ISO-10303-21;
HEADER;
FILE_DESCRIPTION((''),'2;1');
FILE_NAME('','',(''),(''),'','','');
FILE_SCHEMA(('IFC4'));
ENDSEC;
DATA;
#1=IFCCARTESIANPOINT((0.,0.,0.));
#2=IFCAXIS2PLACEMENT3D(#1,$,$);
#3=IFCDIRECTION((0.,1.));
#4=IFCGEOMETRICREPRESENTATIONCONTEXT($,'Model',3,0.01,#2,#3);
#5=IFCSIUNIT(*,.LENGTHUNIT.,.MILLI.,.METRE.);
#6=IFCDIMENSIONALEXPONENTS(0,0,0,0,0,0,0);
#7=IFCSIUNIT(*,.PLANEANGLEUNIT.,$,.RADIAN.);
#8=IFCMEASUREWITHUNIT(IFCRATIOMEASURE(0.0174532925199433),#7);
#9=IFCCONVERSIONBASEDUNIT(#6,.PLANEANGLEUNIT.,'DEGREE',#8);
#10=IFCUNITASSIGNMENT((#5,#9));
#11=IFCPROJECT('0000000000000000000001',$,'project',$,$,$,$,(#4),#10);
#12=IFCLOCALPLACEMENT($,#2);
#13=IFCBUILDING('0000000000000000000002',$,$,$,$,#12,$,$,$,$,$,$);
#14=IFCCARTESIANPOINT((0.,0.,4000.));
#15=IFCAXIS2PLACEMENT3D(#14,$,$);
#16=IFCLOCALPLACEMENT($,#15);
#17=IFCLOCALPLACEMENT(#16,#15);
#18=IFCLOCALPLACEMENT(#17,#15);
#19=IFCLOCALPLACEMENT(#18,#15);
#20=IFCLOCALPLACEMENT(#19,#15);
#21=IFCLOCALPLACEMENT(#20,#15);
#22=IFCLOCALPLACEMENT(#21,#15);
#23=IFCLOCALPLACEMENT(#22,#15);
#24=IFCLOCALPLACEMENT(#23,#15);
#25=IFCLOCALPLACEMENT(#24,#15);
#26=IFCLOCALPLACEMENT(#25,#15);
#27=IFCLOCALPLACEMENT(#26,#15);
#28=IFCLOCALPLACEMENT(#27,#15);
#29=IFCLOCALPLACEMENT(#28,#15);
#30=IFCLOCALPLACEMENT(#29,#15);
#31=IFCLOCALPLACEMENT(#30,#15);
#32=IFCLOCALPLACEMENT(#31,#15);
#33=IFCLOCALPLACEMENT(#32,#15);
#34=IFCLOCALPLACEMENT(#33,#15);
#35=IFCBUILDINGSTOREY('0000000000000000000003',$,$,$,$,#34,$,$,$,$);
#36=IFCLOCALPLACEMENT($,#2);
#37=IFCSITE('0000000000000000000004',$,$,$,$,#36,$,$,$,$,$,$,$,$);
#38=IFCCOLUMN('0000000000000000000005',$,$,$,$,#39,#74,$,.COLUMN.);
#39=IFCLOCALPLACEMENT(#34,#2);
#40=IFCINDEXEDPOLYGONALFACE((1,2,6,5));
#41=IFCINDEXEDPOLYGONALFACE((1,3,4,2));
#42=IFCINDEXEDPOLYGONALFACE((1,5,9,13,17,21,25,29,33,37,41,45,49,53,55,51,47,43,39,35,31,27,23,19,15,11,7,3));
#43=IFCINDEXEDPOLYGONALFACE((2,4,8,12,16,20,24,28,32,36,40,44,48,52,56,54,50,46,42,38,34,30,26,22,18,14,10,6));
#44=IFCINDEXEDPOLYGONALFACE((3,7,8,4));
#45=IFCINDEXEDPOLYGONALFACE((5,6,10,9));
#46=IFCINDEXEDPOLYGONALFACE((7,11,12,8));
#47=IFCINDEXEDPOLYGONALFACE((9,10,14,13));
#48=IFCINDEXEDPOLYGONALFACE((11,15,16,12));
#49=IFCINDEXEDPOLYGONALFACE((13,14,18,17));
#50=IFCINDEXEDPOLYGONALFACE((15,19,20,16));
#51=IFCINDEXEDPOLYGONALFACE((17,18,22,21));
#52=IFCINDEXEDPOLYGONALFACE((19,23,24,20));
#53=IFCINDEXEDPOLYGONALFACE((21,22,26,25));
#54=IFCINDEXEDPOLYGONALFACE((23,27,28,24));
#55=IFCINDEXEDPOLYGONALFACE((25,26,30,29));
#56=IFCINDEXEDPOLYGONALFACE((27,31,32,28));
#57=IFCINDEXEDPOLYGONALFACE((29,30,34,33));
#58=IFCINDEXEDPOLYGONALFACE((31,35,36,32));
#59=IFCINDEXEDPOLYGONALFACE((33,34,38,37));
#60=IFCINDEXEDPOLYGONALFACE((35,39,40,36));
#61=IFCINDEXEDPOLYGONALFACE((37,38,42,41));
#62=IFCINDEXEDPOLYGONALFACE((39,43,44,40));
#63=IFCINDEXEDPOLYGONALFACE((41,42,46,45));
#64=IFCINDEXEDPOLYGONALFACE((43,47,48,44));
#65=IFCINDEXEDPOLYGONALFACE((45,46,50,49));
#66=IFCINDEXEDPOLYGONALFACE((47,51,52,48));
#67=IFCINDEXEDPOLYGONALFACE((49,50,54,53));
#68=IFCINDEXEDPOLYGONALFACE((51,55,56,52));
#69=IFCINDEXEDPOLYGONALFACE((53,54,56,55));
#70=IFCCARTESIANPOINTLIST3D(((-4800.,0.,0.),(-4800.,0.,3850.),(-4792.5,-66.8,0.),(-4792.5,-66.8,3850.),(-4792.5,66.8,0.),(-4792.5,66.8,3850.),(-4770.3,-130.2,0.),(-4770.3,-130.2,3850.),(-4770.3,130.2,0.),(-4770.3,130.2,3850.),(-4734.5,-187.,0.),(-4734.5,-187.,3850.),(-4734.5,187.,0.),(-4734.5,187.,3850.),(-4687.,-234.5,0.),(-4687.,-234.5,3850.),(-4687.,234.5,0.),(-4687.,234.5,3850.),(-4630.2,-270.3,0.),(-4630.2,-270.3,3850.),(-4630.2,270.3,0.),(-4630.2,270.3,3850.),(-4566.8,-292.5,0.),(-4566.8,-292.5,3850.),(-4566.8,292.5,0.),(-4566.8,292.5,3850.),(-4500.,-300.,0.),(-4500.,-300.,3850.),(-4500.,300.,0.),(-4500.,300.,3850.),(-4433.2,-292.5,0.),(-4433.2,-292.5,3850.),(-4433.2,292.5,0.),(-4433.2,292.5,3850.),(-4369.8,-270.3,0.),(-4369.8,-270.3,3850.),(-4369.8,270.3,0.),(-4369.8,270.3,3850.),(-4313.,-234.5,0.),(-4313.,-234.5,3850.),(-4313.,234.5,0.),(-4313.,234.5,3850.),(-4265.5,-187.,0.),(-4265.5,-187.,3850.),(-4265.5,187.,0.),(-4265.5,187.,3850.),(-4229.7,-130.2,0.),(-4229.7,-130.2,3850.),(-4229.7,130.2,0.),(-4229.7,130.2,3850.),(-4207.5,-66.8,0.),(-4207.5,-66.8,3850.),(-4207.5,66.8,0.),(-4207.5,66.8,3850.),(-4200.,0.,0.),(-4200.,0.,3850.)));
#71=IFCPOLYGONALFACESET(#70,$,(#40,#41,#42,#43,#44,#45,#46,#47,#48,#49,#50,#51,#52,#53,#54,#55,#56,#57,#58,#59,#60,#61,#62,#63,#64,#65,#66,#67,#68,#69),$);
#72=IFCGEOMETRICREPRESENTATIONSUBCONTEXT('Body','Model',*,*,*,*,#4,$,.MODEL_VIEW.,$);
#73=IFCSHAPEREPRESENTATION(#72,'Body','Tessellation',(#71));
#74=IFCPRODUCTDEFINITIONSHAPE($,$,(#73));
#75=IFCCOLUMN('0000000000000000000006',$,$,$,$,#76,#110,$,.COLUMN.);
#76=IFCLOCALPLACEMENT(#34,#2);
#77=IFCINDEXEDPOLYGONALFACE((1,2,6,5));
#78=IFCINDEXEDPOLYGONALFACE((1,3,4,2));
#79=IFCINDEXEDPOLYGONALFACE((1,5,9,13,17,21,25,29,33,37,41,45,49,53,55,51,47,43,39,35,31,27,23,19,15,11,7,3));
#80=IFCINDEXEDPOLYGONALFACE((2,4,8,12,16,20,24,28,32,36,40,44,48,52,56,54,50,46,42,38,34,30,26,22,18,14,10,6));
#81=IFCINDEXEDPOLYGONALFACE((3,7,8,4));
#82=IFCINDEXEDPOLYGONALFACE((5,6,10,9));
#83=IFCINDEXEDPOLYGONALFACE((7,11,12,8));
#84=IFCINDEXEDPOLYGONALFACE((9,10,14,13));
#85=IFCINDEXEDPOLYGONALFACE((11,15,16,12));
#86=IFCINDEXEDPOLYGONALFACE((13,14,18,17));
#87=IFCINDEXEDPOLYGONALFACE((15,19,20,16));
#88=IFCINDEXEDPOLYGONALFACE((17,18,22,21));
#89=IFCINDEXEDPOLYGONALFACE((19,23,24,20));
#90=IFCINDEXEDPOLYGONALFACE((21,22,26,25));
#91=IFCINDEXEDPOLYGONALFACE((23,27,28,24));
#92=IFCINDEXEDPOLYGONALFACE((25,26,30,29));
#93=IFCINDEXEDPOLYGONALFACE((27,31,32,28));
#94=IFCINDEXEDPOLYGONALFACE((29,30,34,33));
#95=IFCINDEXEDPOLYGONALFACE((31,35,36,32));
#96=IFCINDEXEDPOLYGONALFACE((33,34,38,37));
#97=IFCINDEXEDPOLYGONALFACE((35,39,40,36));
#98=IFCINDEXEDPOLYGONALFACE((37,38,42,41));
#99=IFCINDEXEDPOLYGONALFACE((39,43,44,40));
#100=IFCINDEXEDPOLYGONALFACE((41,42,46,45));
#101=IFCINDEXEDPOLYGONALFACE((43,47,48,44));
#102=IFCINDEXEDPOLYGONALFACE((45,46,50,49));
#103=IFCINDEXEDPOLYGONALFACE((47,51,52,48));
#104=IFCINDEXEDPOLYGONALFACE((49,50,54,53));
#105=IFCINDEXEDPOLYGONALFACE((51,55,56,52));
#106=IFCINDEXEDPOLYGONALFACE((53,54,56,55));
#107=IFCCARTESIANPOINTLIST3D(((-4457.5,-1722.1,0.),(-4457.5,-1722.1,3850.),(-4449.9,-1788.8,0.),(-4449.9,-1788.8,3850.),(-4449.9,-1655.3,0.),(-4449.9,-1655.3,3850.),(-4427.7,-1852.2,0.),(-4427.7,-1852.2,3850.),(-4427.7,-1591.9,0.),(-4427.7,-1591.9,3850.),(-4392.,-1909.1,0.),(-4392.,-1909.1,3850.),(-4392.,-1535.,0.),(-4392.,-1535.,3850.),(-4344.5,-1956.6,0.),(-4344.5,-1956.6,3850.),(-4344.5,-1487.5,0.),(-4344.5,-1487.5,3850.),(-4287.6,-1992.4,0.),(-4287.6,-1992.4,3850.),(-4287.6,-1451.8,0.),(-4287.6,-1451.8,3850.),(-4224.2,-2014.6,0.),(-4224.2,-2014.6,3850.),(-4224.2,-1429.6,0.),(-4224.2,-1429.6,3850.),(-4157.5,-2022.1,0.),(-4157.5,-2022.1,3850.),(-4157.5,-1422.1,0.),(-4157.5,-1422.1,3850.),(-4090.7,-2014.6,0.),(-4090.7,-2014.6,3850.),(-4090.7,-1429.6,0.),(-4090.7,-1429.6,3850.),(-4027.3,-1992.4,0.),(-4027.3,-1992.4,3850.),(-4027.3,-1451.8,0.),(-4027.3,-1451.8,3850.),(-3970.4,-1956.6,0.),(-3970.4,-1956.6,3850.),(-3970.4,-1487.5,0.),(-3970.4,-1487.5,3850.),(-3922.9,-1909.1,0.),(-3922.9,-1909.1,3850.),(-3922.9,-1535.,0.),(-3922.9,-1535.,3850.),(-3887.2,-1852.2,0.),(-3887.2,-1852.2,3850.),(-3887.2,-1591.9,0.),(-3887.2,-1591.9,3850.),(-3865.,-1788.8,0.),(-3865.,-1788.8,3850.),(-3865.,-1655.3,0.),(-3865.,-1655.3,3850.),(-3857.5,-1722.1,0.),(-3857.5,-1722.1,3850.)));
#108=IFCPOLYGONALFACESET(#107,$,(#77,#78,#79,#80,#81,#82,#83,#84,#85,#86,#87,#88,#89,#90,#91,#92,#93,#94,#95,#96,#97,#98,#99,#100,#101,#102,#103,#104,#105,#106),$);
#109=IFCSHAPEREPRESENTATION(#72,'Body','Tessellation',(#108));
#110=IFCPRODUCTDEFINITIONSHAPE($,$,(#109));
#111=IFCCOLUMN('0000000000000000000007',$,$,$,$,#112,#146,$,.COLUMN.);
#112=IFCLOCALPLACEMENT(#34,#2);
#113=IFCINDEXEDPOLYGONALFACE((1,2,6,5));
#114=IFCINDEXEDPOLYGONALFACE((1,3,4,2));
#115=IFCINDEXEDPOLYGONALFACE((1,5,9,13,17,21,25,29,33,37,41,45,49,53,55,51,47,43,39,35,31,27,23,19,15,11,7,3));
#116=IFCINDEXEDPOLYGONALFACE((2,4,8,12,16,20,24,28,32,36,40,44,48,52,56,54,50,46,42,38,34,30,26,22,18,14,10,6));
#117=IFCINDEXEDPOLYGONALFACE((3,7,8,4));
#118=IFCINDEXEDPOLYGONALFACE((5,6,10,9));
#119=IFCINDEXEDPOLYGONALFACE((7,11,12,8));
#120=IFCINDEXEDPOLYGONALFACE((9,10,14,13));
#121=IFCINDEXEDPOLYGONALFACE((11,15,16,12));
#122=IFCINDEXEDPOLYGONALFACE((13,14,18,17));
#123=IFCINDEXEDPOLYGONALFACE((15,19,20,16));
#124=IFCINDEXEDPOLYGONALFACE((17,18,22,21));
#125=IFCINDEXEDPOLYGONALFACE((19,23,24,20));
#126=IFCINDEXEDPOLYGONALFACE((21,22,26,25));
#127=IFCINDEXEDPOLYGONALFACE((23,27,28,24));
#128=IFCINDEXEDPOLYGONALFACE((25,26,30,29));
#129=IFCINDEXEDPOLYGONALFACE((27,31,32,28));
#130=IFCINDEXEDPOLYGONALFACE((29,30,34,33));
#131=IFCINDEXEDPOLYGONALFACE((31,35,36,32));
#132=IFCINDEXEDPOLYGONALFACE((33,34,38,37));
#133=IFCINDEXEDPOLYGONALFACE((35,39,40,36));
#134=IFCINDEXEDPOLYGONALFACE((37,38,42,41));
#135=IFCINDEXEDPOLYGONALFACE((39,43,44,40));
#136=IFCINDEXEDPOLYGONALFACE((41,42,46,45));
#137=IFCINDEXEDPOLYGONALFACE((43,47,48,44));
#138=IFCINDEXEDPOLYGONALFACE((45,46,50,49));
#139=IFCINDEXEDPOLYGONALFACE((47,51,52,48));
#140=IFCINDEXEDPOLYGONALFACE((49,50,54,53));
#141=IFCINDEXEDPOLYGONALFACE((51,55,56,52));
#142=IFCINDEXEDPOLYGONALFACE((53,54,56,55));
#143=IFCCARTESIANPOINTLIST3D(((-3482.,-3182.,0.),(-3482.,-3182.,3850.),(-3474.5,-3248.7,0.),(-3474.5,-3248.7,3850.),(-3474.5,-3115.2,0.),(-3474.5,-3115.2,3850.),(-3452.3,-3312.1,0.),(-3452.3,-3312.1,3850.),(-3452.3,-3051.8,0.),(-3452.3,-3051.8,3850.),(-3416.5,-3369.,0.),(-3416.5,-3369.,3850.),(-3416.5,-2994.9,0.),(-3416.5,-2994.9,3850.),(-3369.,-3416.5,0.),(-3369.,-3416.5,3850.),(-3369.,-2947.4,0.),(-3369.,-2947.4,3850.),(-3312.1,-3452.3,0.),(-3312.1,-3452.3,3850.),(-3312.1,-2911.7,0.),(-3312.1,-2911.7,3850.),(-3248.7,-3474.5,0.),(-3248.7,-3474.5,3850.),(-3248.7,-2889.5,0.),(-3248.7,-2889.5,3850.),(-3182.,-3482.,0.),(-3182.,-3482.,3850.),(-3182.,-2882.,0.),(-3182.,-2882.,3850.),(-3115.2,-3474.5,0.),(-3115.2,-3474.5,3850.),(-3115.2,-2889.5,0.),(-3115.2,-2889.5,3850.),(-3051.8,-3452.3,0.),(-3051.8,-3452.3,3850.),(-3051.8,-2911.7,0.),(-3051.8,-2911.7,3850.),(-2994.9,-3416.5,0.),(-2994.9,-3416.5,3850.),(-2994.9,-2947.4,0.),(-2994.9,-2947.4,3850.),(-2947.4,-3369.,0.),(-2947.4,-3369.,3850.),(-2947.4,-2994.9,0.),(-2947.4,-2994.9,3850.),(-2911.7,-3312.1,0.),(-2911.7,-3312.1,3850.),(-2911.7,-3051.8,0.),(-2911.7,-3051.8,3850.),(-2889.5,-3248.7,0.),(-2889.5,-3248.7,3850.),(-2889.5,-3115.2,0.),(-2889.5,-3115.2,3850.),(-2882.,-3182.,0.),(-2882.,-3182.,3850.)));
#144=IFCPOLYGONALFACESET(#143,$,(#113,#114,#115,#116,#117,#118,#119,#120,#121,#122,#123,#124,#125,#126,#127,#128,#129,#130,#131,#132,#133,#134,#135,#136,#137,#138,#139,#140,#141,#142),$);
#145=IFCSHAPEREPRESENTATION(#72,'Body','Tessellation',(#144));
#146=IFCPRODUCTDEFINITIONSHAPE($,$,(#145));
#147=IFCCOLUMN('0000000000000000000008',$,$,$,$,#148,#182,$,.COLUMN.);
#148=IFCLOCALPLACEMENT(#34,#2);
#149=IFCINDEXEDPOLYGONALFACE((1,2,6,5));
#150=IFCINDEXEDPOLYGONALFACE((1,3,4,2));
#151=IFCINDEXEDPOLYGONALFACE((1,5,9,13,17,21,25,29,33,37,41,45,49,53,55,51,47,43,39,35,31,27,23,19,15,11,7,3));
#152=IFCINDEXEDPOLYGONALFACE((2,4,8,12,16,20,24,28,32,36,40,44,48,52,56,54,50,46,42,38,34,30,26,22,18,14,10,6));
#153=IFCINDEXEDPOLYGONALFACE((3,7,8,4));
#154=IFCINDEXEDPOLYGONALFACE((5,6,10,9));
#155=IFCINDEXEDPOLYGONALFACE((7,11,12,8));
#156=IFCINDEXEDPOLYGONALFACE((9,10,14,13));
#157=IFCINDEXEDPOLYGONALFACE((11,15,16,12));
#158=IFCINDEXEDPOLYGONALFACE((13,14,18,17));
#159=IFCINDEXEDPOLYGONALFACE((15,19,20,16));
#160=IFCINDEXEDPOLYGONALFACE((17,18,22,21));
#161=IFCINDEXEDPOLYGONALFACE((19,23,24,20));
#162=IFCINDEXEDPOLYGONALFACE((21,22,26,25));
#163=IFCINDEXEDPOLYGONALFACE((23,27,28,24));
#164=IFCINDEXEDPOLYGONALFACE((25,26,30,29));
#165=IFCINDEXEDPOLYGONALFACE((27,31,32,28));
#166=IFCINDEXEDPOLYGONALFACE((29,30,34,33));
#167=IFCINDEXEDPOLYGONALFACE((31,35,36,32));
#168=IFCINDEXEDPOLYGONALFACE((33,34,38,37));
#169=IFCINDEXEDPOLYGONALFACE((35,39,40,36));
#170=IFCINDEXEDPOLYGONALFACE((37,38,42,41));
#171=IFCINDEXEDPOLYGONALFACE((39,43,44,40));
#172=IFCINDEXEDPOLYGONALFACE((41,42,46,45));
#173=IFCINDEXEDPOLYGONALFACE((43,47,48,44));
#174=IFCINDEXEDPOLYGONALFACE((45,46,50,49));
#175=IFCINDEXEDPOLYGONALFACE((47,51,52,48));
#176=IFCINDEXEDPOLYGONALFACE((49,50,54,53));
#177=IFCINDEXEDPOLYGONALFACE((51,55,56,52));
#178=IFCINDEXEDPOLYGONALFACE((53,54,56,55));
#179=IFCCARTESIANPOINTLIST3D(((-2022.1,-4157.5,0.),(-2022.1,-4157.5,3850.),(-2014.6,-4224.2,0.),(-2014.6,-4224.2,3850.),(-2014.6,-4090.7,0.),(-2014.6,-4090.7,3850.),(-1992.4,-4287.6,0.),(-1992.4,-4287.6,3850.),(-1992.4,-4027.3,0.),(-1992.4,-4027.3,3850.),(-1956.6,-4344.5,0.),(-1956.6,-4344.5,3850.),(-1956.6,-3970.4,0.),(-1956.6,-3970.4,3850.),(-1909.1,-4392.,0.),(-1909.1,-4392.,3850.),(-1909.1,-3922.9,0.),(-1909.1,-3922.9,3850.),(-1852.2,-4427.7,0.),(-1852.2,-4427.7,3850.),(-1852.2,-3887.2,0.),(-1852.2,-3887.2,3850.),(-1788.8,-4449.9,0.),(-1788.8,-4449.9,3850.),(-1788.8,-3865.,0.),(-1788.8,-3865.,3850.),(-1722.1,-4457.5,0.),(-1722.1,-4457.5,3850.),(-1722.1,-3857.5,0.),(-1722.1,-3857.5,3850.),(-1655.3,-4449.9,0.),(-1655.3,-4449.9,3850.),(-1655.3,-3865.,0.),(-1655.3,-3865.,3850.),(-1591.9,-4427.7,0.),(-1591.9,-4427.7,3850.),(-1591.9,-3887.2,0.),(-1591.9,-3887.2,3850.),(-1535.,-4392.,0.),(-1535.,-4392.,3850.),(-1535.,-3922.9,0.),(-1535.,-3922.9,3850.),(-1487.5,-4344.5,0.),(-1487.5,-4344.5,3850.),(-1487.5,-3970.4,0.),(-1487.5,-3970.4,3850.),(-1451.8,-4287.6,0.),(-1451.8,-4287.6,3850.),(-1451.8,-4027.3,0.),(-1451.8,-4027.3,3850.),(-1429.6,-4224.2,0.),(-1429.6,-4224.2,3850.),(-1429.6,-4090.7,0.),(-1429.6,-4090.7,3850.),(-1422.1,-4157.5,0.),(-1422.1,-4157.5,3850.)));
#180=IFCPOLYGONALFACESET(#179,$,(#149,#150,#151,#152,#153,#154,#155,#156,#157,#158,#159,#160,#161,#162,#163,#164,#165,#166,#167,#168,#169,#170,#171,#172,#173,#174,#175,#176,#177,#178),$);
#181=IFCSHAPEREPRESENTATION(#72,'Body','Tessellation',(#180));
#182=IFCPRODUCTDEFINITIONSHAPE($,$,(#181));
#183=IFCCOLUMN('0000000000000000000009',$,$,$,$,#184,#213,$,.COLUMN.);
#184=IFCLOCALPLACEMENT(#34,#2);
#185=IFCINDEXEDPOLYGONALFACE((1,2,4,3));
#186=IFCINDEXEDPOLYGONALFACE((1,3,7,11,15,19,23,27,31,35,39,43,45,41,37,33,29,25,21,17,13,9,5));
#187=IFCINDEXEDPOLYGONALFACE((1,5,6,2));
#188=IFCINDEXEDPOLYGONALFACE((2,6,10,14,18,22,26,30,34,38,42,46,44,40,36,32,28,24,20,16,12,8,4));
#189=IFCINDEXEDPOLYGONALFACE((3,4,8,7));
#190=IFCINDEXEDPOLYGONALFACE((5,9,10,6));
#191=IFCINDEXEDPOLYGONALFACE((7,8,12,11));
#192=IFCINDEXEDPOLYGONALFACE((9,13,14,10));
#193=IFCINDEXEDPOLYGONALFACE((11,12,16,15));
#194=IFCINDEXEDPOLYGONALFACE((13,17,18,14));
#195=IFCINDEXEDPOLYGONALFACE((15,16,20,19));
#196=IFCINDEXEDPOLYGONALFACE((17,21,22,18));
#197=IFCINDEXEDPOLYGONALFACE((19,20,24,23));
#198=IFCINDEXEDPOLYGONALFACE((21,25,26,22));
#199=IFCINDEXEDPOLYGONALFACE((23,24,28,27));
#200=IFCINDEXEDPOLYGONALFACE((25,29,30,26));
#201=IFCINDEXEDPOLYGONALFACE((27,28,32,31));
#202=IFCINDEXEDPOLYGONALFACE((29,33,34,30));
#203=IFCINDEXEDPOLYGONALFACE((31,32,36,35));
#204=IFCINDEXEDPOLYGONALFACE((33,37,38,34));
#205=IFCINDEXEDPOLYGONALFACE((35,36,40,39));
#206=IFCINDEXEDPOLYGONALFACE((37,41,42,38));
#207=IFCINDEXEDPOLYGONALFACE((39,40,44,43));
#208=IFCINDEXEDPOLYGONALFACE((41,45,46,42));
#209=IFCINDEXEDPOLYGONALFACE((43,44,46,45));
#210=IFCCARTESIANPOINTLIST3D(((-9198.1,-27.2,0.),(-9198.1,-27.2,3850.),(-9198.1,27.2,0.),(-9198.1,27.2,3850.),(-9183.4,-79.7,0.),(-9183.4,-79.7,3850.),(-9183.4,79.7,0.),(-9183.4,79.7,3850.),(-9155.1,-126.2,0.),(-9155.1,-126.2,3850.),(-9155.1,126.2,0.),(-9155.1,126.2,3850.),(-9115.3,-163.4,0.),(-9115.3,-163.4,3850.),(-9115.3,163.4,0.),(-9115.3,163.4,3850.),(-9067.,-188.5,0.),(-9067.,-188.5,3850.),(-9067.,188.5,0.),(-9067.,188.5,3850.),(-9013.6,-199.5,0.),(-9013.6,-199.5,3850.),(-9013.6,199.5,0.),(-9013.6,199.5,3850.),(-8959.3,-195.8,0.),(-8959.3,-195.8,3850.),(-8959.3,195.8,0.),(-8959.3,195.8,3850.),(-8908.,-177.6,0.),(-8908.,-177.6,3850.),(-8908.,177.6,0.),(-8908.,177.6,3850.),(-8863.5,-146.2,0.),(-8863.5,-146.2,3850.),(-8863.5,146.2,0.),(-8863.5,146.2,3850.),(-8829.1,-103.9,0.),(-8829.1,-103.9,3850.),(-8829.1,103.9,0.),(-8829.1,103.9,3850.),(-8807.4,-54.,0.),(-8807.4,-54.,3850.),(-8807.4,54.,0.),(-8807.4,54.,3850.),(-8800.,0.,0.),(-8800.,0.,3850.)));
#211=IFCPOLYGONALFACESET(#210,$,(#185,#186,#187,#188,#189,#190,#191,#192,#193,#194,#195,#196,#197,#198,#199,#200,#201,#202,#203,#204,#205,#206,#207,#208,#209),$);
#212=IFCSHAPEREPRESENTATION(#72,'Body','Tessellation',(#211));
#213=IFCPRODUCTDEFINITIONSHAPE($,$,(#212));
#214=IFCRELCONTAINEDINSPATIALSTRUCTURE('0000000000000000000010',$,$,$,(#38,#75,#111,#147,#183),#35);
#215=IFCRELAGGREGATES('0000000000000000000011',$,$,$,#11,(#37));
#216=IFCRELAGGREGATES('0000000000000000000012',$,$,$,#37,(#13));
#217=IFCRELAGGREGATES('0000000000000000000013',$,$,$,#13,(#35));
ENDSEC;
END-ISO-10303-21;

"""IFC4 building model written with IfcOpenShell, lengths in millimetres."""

from ifc_helpers import new_model, entity, si_unit, converted_unit, direction, frame, origin, origin_2d, place, context, subcontext, project, spatial, circle, extrude, element, save


model = new_model("IFC4")

# Units and contexts
model_context = context("Model", 3, precision=0.01, world=origin(), true_north=direction((0.0, 1.0)))
body_context = subcontext(model_context, "Body", "Model", "MODEL_VIEW")
ifc_project = project(units=[si_unit("LENGTHUNIT", "METRE", prefix="MILLI"), converted_unit("PLANEANGLEUNIT", "DEGREE", entity("IfcRatioMeasure", 0.0174532925199433), si_unit("PLANEANGLEUNIT", "RADIAN"), dimensions=[0, 0, 0, 0, 0, 0, 0])], contexts=[model_context])

# Site, building, storey
site_placement = place(None, origin())
site = spatial("IfcSite", under=ifc_project, at=site_placement)
building_placement = place(None, origin())
building = spatial("IfcBuilding", under=site, at=building_placement)
placement_1 = place(None, frame((0.0, 0.0, 4000.0)))
placement_2 = place(placement_1, frame((0.0, 0.0, 4000.0)))
placement_3 = place(placement_2, frame((0.0, 0.0, 4000.0)))
placement_4 = place(placement_3, frame((0.0, 0.0, 4000.0)))
placement_5 = place(placement_4, frame((0.0, 0.0, 4000.0)))
placement_6 = place(placement_5, frame((0.0, 0.0, 4000.0)))
placement_7 = place(placement_6, frame((0.0, 0.0, 4000.0)))
placement_8 = place(placement_7, frame((0.0, 0.0, 4000.0)))
placement_9 = place(placement_8, frame((0.0, 0.0, 4000.0)))
placement_10 = place(placement_9, frame((0.0, 0.0, 4000.0)))
placement_11 = place(placement_10, frame((0.0, 0.0, 4000.0)))
placement_12 = place(placement_11, frame((0.0, 0.0, 4000.0)))
placement_13 = place(placement_12, frame((0.0, 0.0, 4000.0)))
placement_14 = place(placement_13, frame((0.0, 0.0, 4000.0)))
placement_15 = place(placement_14, frame((0.0, 0.0, 4000.0)))
placement_16 = place(placement_15, frame((0.0, 0.0, 4000.0)))
placement_17 = place(placement_16, frame((0.0, 0.0, 4000.0)))
placement_18 = place(placement_17, frame((0.0, 0.0, 4000.0)))
storey_placement = place(placement_18, frame((0.0, 0.0, 4000.0)))
storey = spatial("IfcBuildingStorey", under=building, at=storey_placement)

# Columns
for number, where in (
    (1, (-4500.0, 0.0, 0.0)),
    (2, (-4157.5, -1722.1, 0.0)),
    (3, (-3182.0, -3182.0, 0.0)),
    (4, (-1722.1, -4157.5, 0.0)),
):
    element("IfcColumn", number, at=place(storey_placement, frame(where)), inside=storey, PredefinedType="COLUMN", context=body_context, shape_type="SweptSolid", body=[
        extrude(circle(Radius=300.0, at=origin_2d()), origin(), (0.0, 0.0, 1.0), 3850.0),
    ])
for number, where in (
    (5, (-9000.0, 0.0, 0.0)),
):
    element("IfcColumn", number, at=place(storey_placement, frame(where)), inside=storey, PredefinedType="COLUMN", context=body_context, shape_type="SweptSolid", body=[
        extrude(circle(Radius=200.0, at=origin_2d()), origin(), (0.0, 0.0, 1.0), 3850.0),
    ])

save(model, "model.ifc")
